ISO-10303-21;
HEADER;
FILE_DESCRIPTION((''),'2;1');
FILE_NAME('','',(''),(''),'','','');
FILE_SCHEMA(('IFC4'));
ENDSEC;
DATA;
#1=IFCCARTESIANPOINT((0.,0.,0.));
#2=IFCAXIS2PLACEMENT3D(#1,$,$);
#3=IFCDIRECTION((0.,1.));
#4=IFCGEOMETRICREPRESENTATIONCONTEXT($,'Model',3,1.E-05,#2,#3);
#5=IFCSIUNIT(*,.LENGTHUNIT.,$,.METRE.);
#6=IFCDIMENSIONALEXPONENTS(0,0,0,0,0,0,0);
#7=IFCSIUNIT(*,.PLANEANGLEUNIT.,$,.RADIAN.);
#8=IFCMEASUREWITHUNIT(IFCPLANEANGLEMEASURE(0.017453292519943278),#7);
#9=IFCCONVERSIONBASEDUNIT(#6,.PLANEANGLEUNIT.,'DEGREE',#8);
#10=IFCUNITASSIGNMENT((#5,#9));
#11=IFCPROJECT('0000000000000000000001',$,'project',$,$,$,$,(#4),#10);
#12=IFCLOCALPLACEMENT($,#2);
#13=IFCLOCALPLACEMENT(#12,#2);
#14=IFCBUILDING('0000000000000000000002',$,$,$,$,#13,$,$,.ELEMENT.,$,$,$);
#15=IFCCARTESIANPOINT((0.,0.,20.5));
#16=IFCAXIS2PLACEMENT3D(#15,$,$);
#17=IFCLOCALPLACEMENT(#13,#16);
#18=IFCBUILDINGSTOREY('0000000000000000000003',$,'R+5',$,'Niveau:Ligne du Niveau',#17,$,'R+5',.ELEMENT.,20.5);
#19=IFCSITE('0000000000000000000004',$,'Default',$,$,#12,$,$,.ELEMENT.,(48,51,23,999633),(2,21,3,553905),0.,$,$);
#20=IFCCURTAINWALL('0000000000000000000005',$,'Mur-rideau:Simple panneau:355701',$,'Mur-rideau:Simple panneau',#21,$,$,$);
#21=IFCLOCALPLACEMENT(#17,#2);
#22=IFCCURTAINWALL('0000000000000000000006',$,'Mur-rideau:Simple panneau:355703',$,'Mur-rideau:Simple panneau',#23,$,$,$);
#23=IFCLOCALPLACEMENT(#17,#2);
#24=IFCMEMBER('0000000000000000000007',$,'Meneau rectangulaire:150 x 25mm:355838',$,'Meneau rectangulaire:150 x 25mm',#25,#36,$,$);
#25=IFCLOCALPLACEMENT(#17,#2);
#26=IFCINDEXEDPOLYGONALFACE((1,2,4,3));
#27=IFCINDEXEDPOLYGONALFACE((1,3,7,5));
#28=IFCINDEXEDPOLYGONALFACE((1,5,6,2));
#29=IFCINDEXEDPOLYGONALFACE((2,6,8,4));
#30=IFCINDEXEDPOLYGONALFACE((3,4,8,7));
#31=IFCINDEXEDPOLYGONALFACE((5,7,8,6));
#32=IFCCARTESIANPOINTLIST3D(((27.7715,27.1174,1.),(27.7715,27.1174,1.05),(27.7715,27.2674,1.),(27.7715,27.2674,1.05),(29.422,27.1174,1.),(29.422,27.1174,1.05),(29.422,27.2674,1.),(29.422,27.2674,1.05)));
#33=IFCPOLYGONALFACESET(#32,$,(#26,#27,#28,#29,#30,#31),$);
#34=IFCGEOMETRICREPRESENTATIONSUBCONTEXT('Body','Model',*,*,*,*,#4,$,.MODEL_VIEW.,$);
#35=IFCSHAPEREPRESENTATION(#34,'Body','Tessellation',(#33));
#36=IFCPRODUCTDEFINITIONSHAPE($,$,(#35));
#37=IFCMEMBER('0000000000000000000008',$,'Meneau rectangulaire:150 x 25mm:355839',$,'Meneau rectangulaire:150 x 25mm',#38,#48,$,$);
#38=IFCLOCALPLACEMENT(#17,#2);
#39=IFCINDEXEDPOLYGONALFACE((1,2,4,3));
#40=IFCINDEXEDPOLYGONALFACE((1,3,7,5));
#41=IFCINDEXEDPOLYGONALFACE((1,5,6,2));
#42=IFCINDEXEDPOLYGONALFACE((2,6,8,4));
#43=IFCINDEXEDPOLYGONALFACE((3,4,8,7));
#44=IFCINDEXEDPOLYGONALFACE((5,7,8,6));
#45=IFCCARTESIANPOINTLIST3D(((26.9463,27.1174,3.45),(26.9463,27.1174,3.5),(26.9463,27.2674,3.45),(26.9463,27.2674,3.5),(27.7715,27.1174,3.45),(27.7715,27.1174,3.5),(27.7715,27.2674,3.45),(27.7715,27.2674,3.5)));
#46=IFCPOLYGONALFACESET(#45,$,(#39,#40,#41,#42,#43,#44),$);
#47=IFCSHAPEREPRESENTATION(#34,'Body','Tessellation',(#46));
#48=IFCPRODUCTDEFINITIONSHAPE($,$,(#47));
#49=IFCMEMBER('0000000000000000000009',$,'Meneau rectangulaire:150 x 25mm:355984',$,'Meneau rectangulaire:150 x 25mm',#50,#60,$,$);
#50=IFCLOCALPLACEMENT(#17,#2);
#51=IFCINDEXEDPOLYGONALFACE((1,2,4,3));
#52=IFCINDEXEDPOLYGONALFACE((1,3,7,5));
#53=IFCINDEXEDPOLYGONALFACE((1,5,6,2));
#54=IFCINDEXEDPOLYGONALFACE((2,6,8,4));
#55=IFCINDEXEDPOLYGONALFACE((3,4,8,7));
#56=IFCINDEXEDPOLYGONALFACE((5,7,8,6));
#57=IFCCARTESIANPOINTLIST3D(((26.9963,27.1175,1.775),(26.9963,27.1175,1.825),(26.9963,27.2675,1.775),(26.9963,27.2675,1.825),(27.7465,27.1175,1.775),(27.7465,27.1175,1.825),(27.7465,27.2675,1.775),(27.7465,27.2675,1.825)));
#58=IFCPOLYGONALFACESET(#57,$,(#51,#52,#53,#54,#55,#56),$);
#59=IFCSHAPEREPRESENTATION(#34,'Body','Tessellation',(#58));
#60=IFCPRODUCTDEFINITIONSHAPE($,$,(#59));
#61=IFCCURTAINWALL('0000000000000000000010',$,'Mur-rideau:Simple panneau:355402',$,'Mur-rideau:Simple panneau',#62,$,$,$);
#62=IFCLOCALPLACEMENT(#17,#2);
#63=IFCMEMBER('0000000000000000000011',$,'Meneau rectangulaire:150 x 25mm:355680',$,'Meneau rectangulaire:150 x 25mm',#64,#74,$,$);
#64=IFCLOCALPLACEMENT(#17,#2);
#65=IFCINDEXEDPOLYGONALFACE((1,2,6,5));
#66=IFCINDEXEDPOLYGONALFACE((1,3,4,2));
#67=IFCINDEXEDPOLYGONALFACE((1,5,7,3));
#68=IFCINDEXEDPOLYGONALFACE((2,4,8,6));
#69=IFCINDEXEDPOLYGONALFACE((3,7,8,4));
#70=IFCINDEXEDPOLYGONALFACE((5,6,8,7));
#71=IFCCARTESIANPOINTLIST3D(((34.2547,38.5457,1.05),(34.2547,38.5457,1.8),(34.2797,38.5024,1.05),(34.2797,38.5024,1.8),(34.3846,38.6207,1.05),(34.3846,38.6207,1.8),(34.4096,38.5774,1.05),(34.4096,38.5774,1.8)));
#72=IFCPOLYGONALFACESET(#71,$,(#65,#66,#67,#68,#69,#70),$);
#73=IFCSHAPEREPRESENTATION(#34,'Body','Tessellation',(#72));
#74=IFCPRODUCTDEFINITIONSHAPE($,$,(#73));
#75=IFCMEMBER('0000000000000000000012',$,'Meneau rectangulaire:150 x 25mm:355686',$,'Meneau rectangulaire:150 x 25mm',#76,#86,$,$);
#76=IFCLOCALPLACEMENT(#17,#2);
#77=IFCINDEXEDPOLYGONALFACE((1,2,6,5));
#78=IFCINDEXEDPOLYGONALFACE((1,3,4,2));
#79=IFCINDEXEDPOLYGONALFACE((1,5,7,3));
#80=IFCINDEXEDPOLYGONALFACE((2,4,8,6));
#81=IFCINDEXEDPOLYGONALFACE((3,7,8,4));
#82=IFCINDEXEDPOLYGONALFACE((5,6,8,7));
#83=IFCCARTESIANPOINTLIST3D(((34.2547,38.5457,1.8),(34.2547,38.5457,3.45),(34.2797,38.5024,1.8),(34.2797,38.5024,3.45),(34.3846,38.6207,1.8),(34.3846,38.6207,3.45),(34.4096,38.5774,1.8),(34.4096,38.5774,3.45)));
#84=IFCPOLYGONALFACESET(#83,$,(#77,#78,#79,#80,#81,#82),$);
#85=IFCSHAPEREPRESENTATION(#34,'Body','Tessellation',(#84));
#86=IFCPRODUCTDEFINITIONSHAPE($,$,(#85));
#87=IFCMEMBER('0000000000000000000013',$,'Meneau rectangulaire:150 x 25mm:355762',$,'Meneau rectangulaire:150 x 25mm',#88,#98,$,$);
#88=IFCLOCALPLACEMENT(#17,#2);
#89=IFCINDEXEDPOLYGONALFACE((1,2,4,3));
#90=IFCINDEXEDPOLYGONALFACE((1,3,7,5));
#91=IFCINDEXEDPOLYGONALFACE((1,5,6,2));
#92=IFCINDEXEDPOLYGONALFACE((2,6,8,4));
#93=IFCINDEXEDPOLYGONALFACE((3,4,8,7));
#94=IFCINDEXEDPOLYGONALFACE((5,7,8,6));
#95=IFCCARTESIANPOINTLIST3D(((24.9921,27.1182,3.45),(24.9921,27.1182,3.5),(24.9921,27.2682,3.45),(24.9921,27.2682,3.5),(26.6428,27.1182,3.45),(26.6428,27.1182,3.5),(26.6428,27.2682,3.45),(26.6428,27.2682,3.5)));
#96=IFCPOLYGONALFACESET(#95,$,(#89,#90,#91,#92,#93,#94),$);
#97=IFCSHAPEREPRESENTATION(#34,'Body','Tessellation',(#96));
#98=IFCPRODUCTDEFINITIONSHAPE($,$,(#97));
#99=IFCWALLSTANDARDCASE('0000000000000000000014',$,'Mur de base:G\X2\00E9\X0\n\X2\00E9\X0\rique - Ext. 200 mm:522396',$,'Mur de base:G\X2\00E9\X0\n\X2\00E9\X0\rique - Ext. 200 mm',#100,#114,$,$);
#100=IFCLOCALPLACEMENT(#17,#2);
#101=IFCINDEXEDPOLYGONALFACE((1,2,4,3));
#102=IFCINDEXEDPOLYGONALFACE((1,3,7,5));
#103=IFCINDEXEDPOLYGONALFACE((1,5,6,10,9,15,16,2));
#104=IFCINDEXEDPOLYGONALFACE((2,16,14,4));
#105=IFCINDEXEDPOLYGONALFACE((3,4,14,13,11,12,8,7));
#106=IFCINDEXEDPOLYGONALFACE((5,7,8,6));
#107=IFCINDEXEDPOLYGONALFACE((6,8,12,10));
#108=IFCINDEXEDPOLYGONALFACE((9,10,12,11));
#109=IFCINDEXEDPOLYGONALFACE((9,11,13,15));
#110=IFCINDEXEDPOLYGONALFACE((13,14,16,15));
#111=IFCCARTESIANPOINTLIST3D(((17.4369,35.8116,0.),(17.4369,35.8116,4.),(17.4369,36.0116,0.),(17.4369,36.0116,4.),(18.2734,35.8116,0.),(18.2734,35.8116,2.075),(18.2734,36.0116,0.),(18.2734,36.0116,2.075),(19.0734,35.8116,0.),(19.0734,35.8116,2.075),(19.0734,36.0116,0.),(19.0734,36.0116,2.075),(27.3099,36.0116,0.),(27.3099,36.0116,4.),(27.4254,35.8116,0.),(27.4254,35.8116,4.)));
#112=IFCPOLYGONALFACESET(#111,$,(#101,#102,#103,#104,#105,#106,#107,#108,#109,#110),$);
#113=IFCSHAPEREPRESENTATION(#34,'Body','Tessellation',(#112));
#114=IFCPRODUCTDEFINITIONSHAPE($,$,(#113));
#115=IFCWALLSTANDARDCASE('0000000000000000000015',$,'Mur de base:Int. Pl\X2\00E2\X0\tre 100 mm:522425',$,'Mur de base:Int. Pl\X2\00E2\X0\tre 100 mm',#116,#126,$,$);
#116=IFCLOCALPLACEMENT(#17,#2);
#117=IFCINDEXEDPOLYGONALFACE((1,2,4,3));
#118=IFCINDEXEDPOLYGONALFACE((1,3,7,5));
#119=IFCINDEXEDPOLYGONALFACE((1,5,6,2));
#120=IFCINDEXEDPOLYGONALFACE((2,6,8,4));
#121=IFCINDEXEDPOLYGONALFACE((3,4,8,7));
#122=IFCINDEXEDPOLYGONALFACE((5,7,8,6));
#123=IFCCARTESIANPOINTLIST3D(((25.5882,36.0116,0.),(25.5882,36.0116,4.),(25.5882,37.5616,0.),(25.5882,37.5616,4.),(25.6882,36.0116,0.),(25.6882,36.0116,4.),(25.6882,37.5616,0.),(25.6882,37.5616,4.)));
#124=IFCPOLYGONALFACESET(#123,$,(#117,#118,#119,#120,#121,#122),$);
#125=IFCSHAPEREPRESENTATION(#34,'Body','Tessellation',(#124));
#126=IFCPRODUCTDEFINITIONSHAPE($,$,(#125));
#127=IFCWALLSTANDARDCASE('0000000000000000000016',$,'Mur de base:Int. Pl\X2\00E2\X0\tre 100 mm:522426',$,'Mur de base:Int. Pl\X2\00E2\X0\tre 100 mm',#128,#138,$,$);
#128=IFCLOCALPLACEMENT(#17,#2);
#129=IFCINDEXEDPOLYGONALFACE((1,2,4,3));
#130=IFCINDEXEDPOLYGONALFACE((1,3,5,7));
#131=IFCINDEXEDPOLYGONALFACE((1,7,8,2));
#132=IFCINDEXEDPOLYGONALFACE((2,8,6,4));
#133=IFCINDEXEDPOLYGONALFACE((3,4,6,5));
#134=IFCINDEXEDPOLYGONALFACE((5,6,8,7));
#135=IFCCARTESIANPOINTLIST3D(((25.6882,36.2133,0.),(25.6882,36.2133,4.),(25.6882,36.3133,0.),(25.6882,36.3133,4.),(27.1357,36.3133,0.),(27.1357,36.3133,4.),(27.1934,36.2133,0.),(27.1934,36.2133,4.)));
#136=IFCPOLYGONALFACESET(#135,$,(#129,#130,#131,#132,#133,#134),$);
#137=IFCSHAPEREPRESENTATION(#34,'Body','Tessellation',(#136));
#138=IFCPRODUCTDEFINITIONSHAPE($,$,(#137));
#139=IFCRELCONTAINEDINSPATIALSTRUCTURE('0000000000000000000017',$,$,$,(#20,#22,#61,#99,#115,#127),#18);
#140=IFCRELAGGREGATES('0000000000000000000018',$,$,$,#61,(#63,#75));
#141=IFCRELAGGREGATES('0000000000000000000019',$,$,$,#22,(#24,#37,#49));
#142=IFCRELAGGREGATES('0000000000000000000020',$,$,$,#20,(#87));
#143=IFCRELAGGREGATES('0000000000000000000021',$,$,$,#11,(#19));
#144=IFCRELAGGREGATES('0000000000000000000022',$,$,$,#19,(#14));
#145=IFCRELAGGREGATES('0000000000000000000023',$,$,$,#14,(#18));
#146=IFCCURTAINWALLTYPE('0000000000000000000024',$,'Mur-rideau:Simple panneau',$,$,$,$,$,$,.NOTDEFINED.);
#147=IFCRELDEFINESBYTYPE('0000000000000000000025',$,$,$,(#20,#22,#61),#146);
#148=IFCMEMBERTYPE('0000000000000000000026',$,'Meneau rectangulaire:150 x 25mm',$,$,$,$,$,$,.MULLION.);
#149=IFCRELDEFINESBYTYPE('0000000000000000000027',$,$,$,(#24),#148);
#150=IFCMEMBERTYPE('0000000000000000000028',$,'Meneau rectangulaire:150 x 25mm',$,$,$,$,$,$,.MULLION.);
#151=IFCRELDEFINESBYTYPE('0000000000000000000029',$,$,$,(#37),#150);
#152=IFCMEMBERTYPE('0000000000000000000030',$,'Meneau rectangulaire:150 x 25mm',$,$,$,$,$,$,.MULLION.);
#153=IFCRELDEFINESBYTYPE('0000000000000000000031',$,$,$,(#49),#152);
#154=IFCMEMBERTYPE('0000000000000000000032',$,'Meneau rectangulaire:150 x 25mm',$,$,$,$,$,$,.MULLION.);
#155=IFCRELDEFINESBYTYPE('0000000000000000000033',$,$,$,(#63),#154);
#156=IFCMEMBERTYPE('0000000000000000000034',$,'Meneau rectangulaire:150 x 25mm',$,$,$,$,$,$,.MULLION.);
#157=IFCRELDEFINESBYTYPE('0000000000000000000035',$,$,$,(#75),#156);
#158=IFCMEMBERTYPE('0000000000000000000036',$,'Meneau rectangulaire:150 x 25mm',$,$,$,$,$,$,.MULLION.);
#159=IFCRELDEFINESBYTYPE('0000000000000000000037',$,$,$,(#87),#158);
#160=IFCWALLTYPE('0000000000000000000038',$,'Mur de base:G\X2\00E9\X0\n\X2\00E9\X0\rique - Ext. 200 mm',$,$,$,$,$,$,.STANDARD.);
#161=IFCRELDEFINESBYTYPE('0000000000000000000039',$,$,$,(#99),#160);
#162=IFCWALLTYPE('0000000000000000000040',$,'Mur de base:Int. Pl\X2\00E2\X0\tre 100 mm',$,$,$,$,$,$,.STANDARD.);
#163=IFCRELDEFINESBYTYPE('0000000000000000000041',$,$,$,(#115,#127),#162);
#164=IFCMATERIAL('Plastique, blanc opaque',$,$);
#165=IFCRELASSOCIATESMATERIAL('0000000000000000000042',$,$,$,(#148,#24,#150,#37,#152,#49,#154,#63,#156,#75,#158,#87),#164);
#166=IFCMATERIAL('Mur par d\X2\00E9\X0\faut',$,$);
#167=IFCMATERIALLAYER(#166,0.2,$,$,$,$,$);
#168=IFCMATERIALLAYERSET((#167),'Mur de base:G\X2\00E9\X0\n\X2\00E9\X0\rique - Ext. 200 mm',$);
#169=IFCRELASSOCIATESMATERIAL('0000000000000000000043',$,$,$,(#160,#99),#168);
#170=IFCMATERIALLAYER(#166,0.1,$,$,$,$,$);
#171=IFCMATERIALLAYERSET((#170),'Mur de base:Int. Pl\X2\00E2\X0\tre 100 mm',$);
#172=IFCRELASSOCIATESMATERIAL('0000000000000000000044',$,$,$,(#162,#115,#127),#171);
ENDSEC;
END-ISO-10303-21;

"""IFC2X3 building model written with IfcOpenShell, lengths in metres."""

from ifc_helpers import new_model, entity, si_unit, converted_unit, direction, frame, frame_2d, origin, origin_2d_with_axis, place, context, subcontext, project, spatial, polyline, rectangle, outline, extrude, source, transform, mapped, material, layer, layer_set, layer_usage, type_object, type_shapes, element, aggregate, save


model = new_model("IFC2X3")

# Units and contexts
model_context = context("Model", 3, precision=1e-05, world=origin(), true_north=direction((0.0, 1.0)))
body_context = subcontext(model_context, "Body", "Model", "MODEL_VIEW")
ifc_project = project(units=[si_unit("LENGTHUNIT", "METRE"), converted_unit("PLANEANGLEUNIT", "DEGREE", entity("IfcPlaneAngleMeasure", 0.017453292519943278), si_unit("PLANEANGLEUNIT", "RADIAN"), dimensions=[0, 0, 0, 0, 0, 0, 0])], contexts=[model_context])

# Site, building, storey
site_placement = place(None, origin())
site = spatial("IfcSite", under=ifc_project, at=site_placement, Name="Default", CompositionType="ELEMENT", RefLatitude=(48, 51, 23, 999633), RefLongitude=(2, 21, 3, 553905), RefElevation=0.0)
building_placement = place(site_placement, origin())
building = spatial("IfcBuilding", under=site, at=building_placement, CompositionType="ELEMENT")
storey_placement = place(building_placement, frame((0.0, 0.0, 20.5)))
storey = spatial("IfcBuildingStorey", under=building, at=storey_placement, Name="R+5", ObjectType="Niveau:Ligne du Niveau", LongName="R+5", CompositionType="ELEMENT", Elevation=20.5)

# Curtain wall
curtain_wall_type = type_object("IfcCurtainWallType", Name="Mur-rideau:Simple panneau", PredefinedType="NOTDEFINED")
curtain_wall_1_placement = place(storey_placement, frame((0.0, 0.0, -20.5)))
curtain_wall_1 = element("IfcCurtainWall", 1, at=curtain_wall_1_placement, inside=storey, type_object=curtain_wall_type, Name="Mur-rideau:Simple panneau:355701", ObjectType="Mur-rideau:Simple panneau")
ifc_material_1 = material(Name="Plastique, blanc opaque")

# Curtain wall
curtain_wall_2_placement = place(storey_placement, frame((0.0, 0.0, -20.5)))
curtain_wall_2 = element("IfcCurtainWall", 2, at=curtain_wall_2_placement, inside=storey, type_object=curtain_wall_type, Name="Mur-rideau:Simple panneau:355703", ObjectType="Mur-rideau:Simple panneau")

# Members
member_type_1 = type_object("IfcMemberType", Name="Meneau rectangulaire:150 x 25mm", PredefinedType="MULLION", material=ifc_material_1)
shared_shape_1 = source(origin(), body_context, "Body", "SweptSolid", [
    extrude(rectangle(XDim=0.05, YDim=0.15, at=frame_2d((0.0, 0.0), x_axis=(1.0, 0.0))), frame((-0.025, 0.0, -1.6505), z_axis=(0.0, 0.0, 1.0), x_axis=(-1.0, 0.0, 0.0)), (0.0, 0.0, 1.0), 1.6505),
])
type_shapes(member_type_1, [shared_shape_1])
member_1_placement = place(curtain_wall_2_placement, frame((27.7715, 27.1924, 21.5), z_axis=(-1.0, 0.0, 0.0), x_axis=(0.0, 0.0, -1.0)))
member_1 = element("IfcMember", 3, at=member_1_placement, type_object=member_type_1, material=ifc_material_1, Name="Meneau rectangulaire:150 x 25mm:355838", ObjectType="Meneau rectangulaire:150 x 25mm", context=body_context, shape_type="MappedRepresentation", body=[
    mapped(shared_shape_1, transform((0.0, 0.0, 0.0), scale=1.0)),
])
member_type_2 = type_object("IfcMemberType", Name="Meneau rectangulaire:150 x 25mm", PredefinedType="MULLION", material=ifc_material_1)
shared_shape_2 = source(origin(), body_context, "Body", "SweptSolid", [
    extrude(rectangle(XDim=0.05, YDim=0.15, at=origin_2d_with_axis()), frame((-0.025, 0.0, -0.8253), z_axis=(0.0, 0.0, 1.0), x_axis=(-1.0, 0.0, 0.0)), (0.0, 0.0, 1.0), 0.8253),
])
type_shapes(member_type_2, [shared_shape_2])
member_2_placement = place(curtain_wall_2_placement, frame((27.7715, 27.1924, 24.0), z_axis=(1.0, 0.0, 0.0), x_axis=(0.0, 0.0, 1.0)))
member_2 = element("IfcMember", 4, at=member_2_placement, type_object=member_type_2, material=ifc_material_1, Name="Meneau rectangulaire:150 x 25mm:355839", ObjectType="Meneau rectangulaire:150 x 25mm", context=body_context, shape_type="MappedRepresentation", body=[
    mapped(shared_shape_2, transform((0.0, 0.0, 0.0), scale=1.0)),
])
member_type_3 = type_object("IfcMemberType", Name="Meneau rectangulaire:150 x 25mm", PredefinedType="MULLION", material=ifc_material_1)
shared_shape_3 = source(origin(), body_context, "Body", "SweptSolid", [
    extrude(rectangle(XDim=0.05, YDim=0.15, at=origin_2d_with_axis()), frame((0.0, 0.0, -0.7503), z_axis=(0.0, 0.0, 1.0), x_axis=(-1.0, 0.0, 0.0)), (0.0, 0.0, 1.0), 0.7503),
])
type_shapes(member_type_3, [shared_shape_3])
member_3_placement = place(curtain_wall_2_placement, frame((27.7465, 27.1925, 22.3), z_axis=(1.0, 0.0, 0.0), x_axis=(0.0, 0.0, 1.0)))
member_3 = element("IfcMember", 5, at=member_3_placement, type_object=member_type_3, material=ifc_material_1, Name="Meneau rectangulaire:150 x 25mm:355984", ObjectType="Meneau rectangulaire:150 x 25mm", context=body_context, shape_type="MappedRepresentation", body=[
    mapped(shared_shape_3, transform((0.0, 0.0, 0.0), scale=1.0)),
])

# Curtain wall, members
curtain_wall_3_placement = place(storey_placement, frame((0.0, 0.0, -20.5)))
curtain_wall_3 = element("IfcCurtainWall", 6, at=curtain_wall_3_placement, inside=storey, type_object=curtain_wall_type, Name="Mur-rideau:Simple panneau:355402", ObjectType="Mur-rideau:Simple panneau")
member_type_4 = type_object("IfcMemberType", Name="Meneau rectangulaire:150 x 25mm", PredefinedType="MULLION", material=ifc_material_1)
shared_shape_4 = source(origin(), body_context, "Body", "SweptSolid", [
    extrude(rectangle(XDim=0.05, YDim=0.15, at=origin_2d_with_axis()), frame((0.0, 0.0, -0.75), z_axis=(0.0, 0.0, 1.0), x_axis=(-1.0, 0.0, 0.0)), (0.0, 0.0, 1.0), 0.75),
])
type_shapes(member_type_4, [shared_shape_4])
member_4_placement = place(curtain_wall_3_placement, frame((34.3322, 38.5615, 21.55), z_axis=(0.0, 0.0, -1.0), x_axis=(0.5, -0.866025, 0.0)))
member_4 = element("IfcMember", 7, at=member_4_placement, type_object=member_type_4, material=ifc_material_1, Name="Meneau rectangulaire:150 x 25mm:355680", ObjectType="Meneau rectangulaire:150 x 25mm", context=body_context, shape_type="MappedRepresentation", body=[
    mapped(shared_shape_4, transform((0.0, 0.0, 0.0), scale=1.0)),
])
member_type_5 = type_object("IfcMemberType", Name="Meneau rectangulaire:150 x 25mm", PredefinedType="MULLION", material=ifc_material_1)
shared_shape_5 = source(origin(), body_context, "Body", "SweptSolid", [
    extrude(rectangle(XDim=0.05, YDim=0.15, at=origin_2d_with_axis()), frame((0.0, 0.0, -1.65), z_axis=(0.0, 0.0, 1.0), x_axis=(-1.0, 0.0, 0.0)), (0.0, 0.0, 1.0), 1.65),
])
type_shapes(member_type_5, [shared_shape_5])
member_5_placement = place(curtain_wall_3_placement, frame((34.3322, 38.5615, 22.3), z_axis=(0.0, 0.0, -1.0), x_axis=(0.5, -0.866025, 0.0)))
member_5 = element("IfcMember", 8, at=member_5_placement, type_object=member_type_5, material=ifc_material_1, Name="Meneau rectangulaire:150 x 25mm:355686", ObjectType="Meneau rectangulaire:150 x 25mm", context=body_context, shape_type="MappedRepresentation", body=[
    mapped(shared_shape_5, transform((0.0, 0.0, 0.0), scale=1.0)),
])
aggregate(curtain_wall_3, [member_4, member_5])

# Member
member_type_6 = type_object("IfcMemberType", Name="Meneau rectangulaire:150 x 25mm", PredefinedType="MULLION", material=ifc_material_1)
shared_shape_6 = source(origin(), body_context, "Body", "SweptSolid", [
    extrude(rectangle(XDim=0.05, YDim=0.15, at=origin_2d_with_axis()), frame((-0.025, 0.0, -1.6507), z_axis=(0.0, 0.0, 1.0), x_axis=(-1.0, 0.0, 0.0)), (0.0, 0.0, 1.0), 1.6507),
])
type_shapes(member_type_6, [shared_shape_6])
member_6_placement = place(curtain_wall_1_placement, frame((26.6428, 27.1932, 24.0), z_axis=(1.0, 0.0, 0.0), x_axis=(0.0, 0.0, 1.0)))
member_6 = element("IfcMember", 9, at=member_6_placement, type_object=member_type_6, material=ifc_material_1, Name="Meneau rectangulaire:150 x 25mm:355762", ObjectType="Meneau rectangulaire:150 x 25mm", context=body_context, shape_type="MappedRepresentation", body=[
    mapped(shared_shape_6, transform((0.0, 0.0, 0.0), scale=1.0)),
])

aggregate(curtain_wall_2, [member_1, member_2, member_3])
aggregate(curtain_wall_1, [member_6])

# Wall, opening
ifc_material_2 = material(Name="Mur par défaut")
ifc_layer_1 = layer(ifc_material_2, 0.2)
ifc_layer_set_1 = layer_set([ifc_layer_1], Name="Mur de base:Générique - Ext. 200 mm")
ifc_layer_usage_1 = layer_usage(ifc_layer_set_1, "AXIS2", "NEGATIVE", 0.1)
wall_type_1 = type_object("IfcWallType", Name="Mur de base:Générique - Ext. 200 mm", PredefinedType="STANDARD", material=ifc_layer_set_1)
wall_1_placement = place(storey_placement, frame((27.4254, 35.9116, 0.0), z_axis=(0.0, 0.0, 1.0), x_axis=(-1.0, 0.0, 0.0)))
wall_1 = element("IfcWallStandardCase", 10, at=wall_1_placement, inside=storey, type_object=wall_type_1, material=ifc_layer_usage_1, Name="Mur de base:Générique - Ext. 200 mm:522396", ObjectType="Mur de base:Générique - Ext. 200 mm", context=body_context, shape_type="SweptSolid", body=[
    extrude(outline(polyline([(0.1155, -0.1), (1.7371, -0.1), (1.8371, -0.1), (3.2871, -0.1), (3.3871, -0.1), (5.1396, -0.1), (5.2396, -0.1), (7.482, -0.1), (7.582, -0.1), (9.392, -0.1), (9.592, -0.1), (9.9884, -0.1), (9.9884, 0.1), (0.0, 0.1), (0.1155, -0.1)])), origin(), (0.0, 0.0, 1.0), 4.0),
])
opening_placement = place(wall_1_placement, frame((9.152, 0.1, 0.0)))
element("IfcOpeningElement", 11, at=opening_placement, cuts=wall_1, ObjectType="Opening", context=body_context, shape_type="SweptSolid", body=[
    extrude(rectangle(XDim=2.075, YDim=0.8, at=frame_2d((1.0375, 0.4), x_axis=(1.0, 0.0))), frame((0.0, 0.0, 0.0), z_axis=(0.0, -1.0, 0.0), x_axis=(0.0, 0.0, 1.0)), (0.0, 0.0, 1.0), 0.2),
])

# Walls
ifc_layer_2 = layer(ifc_material_2, 0.1)
ifc_layer_set_2 = layer_set([ifc_layer_2], Name="Mur de base:Int. Plâtre 100 mm")
ifc_layer_usage_2 = layer_usage(ifc_layer_set_2, "AXIS2", "NEGATIVE", 0.05)
wall_type_2 = type_object("IfcWallType", Name="Mur de base:Int. Plâtre 100 mm", PredefinedType="STANDARD", material=ifc_layer_set_2)
wall_2_placement = place(storey_placement, frame((25.6382, 37.5616, 0.0), z_axis=(0.0, 0.0, 1.0), x_axis=(0.0, -1.0, 0.0)))
element("IfcWallStandardCase", 12, at=wall_2_placement, inside=storey, type_object=wall_type_2, material=ifc_layer_usage_2, Name="Mur de base:Int. Plâtre 100 mm:522425", ObjectType="Mur de base:Int. Plâtre 100 mm", context=body_context, shape_type="SweptSolid", body=[
    extrude(rectangle(XDim=1.55, YDim=0.1, at=frame_2d((0.775, 0.0), x_axis=(-1.0, 0.0))), origin(), (0.0, 0.0, 1.0), 4.0),
])
ifc_layer_usage_3 = layer_usage(ifc_layer_set_2, "AXIS2", "NEGATIVE", 0.05)
wall_3_placement = place(storey_placement, frame((27.1934, 36.2633, 0.0), z_axis=(0.0, 0.0, 1.0), x_axis=(-1.0, 0.0, 0.0)))
element("IfcWallStandardCase", 13, at=wall_3_placement, inside=storey, type_object=wall_type_2, material=ifc_layer_usage_3, Name="Mur de base:Int. Plâtre 100 mm:522426", ObjectType="Mur de base:Int. Plâtre 100 mm", context=body_context, shape_type="SweptSolid", body=[
    extrude(outline(polyline([(1.5052, -0.05), (1.5052, 0.05), (0.0, 0.05), (0.0577, -0.05), (1.5052, -0.05)])), origin(), (0.0, 0.0, 1.0), 4.0),
])

save(model, "model.ifc")
